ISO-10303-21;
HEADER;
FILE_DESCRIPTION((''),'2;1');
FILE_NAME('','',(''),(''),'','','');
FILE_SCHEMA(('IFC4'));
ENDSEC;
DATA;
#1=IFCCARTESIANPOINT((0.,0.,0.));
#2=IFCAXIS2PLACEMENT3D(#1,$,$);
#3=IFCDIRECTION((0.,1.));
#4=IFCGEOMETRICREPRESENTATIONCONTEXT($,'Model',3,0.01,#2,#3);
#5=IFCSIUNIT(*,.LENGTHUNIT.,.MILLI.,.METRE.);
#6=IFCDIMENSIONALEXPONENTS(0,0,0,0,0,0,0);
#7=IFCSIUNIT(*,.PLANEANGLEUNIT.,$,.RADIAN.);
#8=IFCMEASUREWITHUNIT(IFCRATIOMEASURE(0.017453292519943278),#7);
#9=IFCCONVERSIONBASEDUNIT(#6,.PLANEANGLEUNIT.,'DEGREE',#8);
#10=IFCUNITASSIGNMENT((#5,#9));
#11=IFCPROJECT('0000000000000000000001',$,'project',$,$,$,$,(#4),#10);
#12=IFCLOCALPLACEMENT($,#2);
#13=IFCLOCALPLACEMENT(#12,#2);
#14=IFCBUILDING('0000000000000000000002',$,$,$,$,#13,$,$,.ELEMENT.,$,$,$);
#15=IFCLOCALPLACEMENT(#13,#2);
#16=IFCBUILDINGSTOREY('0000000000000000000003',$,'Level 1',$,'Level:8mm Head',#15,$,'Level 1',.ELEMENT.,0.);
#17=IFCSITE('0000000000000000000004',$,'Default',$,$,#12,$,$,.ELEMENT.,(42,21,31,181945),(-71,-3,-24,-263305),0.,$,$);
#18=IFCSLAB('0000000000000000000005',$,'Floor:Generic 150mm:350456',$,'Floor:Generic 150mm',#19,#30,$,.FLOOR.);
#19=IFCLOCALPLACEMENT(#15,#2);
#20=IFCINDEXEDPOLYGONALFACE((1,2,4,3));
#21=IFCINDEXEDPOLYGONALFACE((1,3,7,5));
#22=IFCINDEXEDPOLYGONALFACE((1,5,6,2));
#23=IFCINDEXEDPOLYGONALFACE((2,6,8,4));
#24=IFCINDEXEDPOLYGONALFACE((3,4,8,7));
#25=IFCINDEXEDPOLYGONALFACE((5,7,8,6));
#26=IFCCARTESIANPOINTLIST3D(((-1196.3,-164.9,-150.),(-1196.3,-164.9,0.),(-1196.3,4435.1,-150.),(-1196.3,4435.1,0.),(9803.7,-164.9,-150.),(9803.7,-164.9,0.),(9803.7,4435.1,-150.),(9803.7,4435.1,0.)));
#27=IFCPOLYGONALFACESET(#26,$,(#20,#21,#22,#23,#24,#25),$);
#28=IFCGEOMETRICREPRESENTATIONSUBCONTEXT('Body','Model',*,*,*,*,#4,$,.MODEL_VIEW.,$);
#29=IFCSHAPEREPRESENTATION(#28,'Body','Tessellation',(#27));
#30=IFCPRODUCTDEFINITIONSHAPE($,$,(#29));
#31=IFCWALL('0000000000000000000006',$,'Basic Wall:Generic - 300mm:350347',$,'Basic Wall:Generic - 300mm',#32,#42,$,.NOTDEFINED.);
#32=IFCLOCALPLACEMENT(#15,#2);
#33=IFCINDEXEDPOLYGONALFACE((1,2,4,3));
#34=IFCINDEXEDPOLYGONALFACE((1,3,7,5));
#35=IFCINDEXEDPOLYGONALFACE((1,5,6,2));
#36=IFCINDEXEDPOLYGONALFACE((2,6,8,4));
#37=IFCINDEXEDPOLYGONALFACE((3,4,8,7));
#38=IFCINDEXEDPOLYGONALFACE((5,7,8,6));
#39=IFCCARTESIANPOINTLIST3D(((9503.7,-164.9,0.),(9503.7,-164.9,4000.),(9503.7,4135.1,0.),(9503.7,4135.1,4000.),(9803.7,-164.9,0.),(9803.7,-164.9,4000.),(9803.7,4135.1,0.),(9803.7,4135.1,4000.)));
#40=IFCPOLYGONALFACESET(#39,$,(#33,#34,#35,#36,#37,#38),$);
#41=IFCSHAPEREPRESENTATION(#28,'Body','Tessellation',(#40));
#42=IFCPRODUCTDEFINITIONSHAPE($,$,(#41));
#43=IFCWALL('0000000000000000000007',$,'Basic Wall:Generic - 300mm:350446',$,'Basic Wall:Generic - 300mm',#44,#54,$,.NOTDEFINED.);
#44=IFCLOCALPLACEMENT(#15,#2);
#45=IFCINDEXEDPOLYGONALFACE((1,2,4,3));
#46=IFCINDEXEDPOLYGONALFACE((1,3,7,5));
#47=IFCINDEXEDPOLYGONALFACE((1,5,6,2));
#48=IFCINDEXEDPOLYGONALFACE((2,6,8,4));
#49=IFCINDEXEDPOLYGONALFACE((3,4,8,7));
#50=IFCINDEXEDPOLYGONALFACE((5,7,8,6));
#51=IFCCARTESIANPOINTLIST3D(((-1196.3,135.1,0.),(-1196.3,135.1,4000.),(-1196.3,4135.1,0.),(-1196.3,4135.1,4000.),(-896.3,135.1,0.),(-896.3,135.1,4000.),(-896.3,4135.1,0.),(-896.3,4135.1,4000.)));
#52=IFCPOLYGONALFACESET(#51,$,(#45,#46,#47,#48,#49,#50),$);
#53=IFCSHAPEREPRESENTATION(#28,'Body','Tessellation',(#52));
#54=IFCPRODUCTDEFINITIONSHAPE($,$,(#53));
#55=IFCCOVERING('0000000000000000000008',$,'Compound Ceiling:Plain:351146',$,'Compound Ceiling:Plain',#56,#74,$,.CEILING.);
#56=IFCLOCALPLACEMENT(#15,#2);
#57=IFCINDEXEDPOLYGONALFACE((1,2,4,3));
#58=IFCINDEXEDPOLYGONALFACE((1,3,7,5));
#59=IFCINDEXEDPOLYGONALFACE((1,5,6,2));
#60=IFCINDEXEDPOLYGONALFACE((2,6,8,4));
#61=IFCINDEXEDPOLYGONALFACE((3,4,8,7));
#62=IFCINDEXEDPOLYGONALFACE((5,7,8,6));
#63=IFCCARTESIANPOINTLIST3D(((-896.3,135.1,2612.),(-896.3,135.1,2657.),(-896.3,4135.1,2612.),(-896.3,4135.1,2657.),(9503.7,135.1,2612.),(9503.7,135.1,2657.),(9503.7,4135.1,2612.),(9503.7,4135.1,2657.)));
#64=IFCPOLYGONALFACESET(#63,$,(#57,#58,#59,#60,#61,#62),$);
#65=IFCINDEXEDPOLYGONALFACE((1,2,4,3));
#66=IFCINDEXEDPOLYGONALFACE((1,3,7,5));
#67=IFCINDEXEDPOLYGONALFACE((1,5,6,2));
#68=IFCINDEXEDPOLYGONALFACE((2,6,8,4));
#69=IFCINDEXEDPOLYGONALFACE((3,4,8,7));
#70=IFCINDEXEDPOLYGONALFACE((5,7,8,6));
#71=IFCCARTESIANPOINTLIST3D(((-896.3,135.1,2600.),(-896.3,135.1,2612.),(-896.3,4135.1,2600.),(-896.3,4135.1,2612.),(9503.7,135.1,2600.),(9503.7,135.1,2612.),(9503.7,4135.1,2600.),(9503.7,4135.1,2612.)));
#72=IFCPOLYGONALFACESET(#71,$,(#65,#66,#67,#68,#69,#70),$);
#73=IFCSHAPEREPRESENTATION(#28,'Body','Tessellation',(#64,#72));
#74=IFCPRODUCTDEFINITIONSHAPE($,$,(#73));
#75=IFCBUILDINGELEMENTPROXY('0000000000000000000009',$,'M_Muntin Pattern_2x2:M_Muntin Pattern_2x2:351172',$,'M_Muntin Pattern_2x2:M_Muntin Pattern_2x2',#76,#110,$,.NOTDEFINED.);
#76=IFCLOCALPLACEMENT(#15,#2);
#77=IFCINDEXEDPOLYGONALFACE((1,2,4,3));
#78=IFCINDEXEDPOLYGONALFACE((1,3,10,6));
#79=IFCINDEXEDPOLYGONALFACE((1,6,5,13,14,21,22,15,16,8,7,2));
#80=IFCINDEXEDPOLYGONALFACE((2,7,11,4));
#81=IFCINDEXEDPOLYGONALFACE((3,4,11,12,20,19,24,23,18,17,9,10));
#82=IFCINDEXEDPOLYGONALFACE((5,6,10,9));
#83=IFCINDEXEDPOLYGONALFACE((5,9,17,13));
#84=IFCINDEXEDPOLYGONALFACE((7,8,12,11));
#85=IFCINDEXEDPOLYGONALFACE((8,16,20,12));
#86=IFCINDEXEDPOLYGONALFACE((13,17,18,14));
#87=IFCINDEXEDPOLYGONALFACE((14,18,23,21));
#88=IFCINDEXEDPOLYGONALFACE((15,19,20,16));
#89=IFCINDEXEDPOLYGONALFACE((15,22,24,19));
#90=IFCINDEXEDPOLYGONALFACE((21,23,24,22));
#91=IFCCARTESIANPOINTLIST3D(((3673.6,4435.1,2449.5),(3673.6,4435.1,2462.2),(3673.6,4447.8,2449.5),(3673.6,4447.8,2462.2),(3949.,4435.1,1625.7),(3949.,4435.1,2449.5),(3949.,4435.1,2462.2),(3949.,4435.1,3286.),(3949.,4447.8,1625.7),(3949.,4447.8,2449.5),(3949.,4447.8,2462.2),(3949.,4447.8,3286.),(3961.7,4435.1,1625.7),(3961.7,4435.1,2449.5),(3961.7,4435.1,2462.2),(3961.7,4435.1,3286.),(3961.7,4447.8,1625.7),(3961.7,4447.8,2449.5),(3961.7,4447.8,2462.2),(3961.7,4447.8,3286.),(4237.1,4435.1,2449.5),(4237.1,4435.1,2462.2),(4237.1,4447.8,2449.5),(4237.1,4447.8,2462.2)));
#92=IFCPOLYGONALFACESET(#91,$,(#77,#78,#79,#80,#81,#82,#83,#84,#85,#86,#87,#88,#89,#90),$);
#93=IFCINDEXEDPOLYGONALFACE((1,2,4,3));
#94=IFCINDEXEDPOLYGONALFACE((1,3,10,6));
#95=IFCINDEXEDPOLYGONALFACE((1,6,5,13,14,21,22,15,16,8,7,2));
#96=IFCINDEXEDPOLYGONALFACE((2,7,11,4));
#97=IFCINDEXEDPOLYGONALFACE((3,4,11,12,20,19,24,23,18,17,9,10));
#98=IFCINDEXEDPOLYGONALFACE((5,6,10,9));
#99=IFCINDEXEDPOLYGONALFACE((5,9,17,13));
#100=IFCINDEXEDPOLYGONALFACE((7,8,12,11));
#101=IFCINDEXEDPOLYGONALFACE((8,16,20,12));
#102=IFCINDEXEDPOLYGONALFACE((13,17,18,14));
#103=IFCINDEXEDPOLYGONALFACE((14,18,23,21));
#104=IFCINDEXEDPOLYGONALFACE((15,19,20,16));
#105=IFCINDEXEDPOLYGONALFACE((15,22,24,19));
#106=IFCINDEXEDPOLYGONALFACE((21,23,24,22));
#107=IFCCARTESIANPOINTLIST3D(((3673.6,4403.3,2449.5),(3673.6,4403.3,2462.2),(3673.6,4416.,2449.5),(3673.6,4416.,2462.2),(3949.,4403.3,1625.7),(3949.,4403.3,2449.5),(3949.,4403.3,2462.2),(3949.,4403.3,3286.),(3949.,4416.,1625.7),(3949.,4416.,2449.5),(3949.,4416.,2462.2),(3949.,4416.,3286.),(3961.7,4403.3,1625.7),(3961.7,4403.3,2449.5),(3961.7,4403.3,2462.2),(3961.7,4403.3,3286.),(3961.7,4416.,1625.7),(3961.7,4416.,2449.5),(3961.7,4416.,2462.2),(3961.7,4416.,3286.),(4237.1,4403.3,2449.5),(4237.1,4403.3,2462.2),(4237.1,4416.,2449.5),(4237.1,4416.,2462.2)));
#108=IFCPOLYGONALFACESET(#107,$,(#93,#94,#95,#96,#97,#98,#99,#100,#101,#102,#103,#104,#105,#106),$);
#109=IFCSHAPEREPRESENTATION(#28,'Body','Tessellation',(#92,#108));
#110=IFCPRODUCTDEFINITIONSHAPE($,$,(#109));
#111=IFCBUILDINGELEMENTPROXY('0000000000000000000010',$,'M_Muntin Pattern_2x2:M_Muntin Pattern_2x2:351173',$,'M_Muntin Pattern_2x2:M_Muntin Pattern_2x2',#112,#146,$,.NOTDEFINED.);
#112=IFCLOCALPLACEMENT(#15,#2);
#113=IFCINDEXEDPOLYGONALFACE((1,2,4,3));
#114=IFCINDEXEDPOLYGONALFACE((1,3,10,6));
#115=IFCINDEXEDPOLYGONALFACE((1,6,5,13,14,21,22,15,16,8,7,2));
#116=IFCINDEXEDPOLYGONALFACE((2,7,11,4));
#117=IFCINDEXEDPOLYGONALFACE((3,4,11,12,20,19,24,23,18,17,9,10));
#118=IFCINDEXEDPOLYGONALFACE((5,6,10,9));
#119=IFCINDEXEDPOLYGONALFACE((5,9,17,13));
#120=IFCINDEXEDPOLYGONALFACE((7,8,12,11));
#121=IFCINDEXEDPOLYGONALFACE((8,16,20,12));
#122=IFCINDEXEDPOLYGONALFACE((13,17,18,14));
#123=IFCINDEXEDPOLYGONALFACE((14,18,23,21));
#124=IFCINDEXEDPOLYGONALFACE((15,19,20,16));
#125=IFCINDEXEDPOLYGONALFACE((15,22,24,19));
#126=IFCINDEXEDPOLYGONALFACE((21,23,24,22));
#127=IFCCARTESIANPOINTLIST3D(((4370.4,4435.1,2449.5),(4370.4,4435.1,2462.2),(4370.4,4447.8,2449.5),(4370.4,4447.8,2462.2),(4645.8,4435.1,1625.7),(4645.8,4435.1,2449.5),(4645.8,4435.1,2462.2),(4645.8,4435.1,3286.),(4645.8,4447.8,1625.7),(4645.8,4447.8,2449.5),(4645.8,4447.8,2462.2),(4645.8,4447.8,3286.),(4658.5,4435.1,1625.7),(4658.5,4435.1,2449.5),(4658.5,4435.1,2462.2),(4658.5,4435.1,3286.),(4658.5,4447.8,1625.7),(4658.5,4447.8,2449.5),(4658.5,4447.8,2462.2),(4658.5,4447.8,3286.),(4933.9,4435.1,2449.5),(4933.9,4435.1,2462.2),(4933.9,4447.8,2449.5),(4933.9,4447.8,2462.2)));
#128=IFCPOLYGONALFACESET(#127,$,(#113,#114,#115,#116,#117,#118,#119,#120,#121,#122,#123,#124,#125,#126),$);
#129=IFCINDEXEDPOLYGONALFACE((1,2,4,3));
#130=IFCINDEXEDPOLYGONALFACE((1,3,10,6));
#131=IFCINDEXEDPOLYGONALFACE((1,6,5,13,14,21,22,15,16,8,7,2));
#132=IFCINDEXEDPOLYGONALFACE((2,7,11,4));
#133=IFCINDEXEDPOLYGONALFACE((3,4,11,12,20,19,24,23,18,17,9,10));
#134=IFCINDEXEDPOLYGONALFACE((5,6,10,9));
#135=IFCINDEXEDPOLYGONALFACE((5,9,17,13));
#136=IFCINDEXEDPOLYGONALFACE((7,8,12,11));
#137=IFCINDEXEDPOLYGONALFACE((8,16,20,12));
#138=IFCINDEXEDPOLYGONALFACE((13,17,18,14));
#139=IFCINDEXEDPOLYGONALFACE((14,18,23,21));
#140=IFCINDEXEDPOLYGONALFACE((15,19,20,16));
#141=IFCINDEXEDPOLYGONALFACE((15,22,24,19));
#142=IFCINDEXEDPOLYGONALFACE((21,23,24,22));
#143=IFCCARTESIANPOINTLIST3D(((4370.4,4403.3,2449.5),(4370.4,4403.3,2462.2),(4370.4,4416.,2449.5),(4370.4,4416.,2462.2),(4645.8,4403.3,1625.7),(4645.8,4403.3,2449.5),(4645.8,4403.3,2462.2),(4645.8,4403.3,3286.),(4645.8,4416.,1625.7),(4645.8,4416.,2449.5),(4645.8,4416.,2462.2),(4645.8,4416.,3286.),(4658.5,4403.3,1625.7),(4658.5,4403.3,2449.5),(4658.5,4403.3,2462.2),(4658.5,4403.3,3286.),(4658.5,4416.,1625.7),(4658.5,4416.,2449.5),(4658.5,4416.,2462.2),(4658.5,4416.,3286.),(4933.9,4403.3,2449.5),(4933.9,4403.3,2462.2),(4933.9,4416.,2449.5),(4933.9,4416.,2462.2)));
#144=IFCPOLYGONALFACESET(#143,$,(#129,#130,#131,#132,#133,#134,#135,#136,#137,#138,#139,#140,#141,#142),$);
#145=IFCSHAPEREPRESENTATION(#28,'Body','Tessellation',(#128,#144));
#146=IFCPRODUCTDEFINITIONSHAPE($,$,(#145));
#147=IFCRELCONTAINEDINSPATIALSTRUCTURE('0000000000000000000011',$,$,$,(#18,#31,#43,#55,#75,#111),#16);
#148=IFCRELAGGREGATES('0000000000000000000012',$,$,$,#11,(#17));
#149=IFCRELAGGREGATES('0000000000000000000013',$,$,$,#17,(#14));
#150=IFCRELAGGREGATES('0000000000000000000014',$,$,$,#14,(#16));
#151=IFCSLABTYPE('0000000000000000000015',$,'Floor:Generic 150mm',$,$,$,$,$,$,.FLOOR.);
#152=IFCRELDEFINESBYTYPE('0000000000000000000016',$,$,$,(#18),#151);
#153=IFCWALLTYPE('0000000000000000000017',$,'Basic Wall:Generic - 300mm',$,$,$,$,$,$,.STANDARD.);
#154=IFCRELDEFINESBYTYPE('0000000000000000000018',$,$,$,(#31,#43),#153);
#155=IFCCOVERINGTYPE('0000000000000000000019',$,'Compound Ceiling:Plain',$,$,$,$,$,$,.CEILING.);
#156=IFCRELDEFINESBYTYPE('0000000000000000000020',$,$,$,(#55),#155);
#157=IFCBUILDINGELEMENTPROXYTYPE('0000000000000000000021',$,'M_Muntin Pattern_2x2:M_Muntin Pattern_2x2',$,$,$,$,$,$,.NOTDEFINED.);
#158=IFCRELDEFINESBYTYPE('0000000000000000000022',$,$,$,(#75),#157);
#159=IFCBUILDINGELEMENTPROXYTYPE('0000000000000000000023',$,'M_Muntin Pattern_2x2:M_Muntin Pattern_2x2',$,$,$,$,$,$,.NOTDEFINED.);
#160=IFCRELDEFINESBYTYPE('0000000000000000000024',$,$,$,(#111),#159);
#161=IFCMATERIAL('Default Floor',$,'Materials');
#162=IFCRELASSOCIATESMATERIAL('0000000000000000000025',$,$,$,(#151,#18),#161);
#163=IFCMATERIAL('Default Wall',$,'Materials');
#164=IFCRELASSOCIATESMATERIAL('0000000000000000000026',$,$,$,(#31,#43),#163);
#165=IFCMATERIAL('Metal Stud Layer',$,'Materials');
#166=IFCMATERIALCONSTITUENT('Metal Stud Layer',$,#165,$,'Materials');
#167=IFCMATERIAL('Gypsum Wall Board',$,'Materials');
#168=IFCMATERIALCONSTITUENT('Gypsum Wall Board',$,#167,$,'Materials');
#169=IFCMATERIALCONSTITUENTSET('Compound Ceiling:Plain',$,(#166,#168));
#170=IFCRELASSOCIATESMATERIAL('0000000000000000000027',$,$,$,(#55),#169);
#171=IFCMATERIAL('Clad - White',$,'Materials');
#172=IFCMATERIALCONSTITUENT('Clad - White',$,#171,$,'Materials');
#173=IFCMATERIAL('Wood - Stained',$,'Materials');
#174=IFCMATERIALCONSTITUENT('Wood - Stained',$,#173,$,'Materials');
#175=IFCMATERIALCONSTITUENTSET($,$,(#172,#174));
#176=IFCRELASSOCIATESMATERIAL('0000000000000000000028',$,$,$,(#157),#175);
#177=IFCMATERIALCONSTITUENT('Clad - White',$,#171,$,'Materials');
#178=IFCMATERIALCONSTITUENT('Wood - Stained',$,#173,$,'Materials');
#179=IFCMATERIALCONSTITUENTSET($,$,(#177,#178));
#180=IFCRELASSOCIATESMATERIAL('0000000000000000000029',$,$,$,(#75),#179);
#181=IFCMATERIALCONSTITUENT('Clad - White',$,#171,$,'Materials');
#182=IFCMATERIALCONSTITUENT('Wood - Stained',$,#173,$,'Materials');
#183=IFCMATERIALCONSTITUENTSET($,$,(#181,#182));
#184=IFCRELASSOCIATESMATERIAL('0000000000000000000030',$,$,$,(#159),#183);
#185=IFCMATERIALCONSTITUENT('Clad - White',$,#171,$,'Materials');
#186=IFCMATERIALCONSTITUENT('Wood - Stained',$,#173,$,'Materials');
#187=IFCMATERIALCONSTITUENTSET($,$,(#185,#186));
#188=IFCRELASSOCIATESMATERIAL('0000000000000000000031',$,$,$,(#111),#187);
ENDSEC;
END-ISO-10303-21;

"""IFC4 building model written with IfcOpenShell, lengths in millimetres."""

from ifc_helpers import new_model, entity, si_unit, converted_unit, direction, frame, origin, place, context, subcontext, project, spatial, indexed_curve, outline, extrude, source, transform, mapped, material, constituent, constituent_set, type_object, type_shapes, element, save


model = new_model("IFC4")

# Units and contexts
model_context = context("Model", 3, precision=0.01, world=origin(), true_north=direction((0.0, 1.0)))
body_context = subcontext(model_context, "Body", "Model", "MODEL_VIEW")
ifc_project = project(units=[si_unit("LENGTHUNIT", "METRE", prefix="MILLI"), converted_unit("PLANEANGLEUNIT", "DEGREE", entity("IfcRatioMeasure", 0.017453292519943278), si_unit("PLANEANGLEUNIT", "RADIAN"), dimensions=[0, 0, 0, 0, 0, 0, 0])], contexts=[model_context])

# Site, building, storey
site_placement = place(None, origin())
site = spatial("IfcSite", under=ifc_project, at=site_placement, Name="Default", CompositionType="ELEMENT", RefLatitude=(42, 21, 31, 181945), RefLongitude=(-71, -3, -24, -263305), RefElevation=0.0)
building_placement = place(site_placement, origin())
building = spatial("IfcBuilding", under=site, at=building_placement, CompositionType="ELEMENT")
storey_placement = place(building_placement, origin())
storey = spatial("IfcBuildingStorey", under=building, at=storey_placement, Name="Level 1", ObjectType="Level:8mm Head", LongName="Level 1", CompositionType="ELEMENT", Elevation=0.0)

# Slab
ifc_material_1 = material(Name="Default Floor", Category="Materials")
slab_type = type_object("IfcSlabType", Name="Floor:Generic 150mm", PredefinedType="FLOOR", material=ifc_material_1)
slab_placement = place(storey_placement, origin())
element("IfcSlab", 1, at=slab_placement, inside=storey, type_object=slab_type, material=ifc_material_1, Name="Floor:Generic 150mm:350456", ObjectType="Floor:Generic 150mm", PredefinedType="FLOOR", context=body_context, shape_type="SweptSolid", body=[
    extrude(outline(indexed_curve([(-2300.0, -5500.0), (2300.0, -5500.0), (2300.0, 5500.0), (-2300.0, 5500.0), (-2300.0, -5500.0)], self_intersect=False)), frame((4303.7, 2135.1, 0.0), z_axis=(0.0, 0.0, -1.0), x_axis=(0.0, 1.0, 0.0)), (0.0, 0.0, 1.0), 150.0),
])

# Walls
ifc_material_2 = material(Name="Default Wall", Category="Materials")
wall_type = type_object("IfcWallType", Name="Basic Wall:Generic - 300mm", PredefinedType="STANDARD")
wall_1_placement = place(storey_placement, frame((9653.7, 4135.1, 0.0), z_axis=(0.0, 0.0, 1.0), x_axis=(0.0, -1.0, 0.0)))
element("IfcWall", 2, at=wall_1_placement, inside=storey, type_object=wall_type, material=ifc_material_2, Name="Basic Wall:Generic - 300mm:350347", ObjectType="Basic Wall:Generic - 300mm", PredefinedType="NOTDEFINED", context=body_context, shape_type="SweptSolid", body=[
    extrude(outline(indexed_curve([(4300.0, 150.0), (0.0, 150.0), (0.0, -150.0), (4300.0, -150.0), (4300.0, 150.0)], self_intersect=False)), origin(), (0.0, 0.0, 1.0), 4000.0),
])
wall_2_placement = place(storey_placement, frame((-1046.3, 135.1, 0.0), z_axis=(0.0, 0.0, 1.0), x_axis=(0.0, 1.0, 0.0)))
element("IfcWall", 3, at=wall_2_placement, inside=storey, type_object=wall_type, material=ifc_material_2, Name="Basic Wall:Generic - 300mm:350446", ObjectType="Basic Wall:Generic - 300mm", PredefinedType="NOTDEFINED", context=body_context, shape_type="SweptSolid", body=[
    extrude(outline(indexed_curve([(4000.0, 150.0), (0.0, 150.0), (0.0, -150.0), (4000.0, -150.0), (4000.0, 150.0)], self_intersect=False)), origin(), (0.0, 0.0, 1.0), 4000.0),
])

# Covering
ifc_material_3 = material(Name="Metal Stud Layer", Category="Materials")
ifc_constituent_1 = constituent(ifc_material_3, Name="Metal Stud Layer", Category="Materials")
ifc_material_4 = material(Name="Gypsum Wall Board", Category="Materials")
ifc_constituent_2 = constituent(ifc_material_4, Name="Gypsum Wall Board", Category="Materials")
ifc_constituent_set_1 = constituent_set(constituents=[ifc_constituent_1, ifc_constituent_2], Name="Compound Ceiling:Plain")
covering_type = type_object("IfcCoveringType", Name="Compound Ceiling:Plain", PredefinedType="CEILING")
covering_placement = place(storey_placement, origin())
element("IfcCovering", 4, at=covering_placement, inside=storey, type_object=covering_type, material=ifc_constituent_set_1, Name="Compound Ceiling:Plain:351146", ObjectType="Compound Ceiling:Plain", PredefinedType="CEILING", context=body_context, shape_type="SweptSolid", body=[
    extrude(outline(indexed_curve([(-5200.0, -2000.0), (5200.0, -2000.0), (5200.0, 2000.0), (-5200.0, 2000.0), (-5200.0, -2000.0)], self_intersect=False)), frame((4303.7, 2135.1, 2612.0)), (0.0, 0.0, 1.0), 45.0),
    extrude(outline(indexed_curve([(-2000.0, -5200.0), (2000.0, -5200.0), (2000.0, 5200.0), (-2000.0, 5200.0), (-2000.0, -5200.0)], self_intersect=False)), frame((4303.7, 2135.1, 2600.0), z_axis=(0.0, 0.0, 1.0), x_axis=(0.0, -1.0, 0.0)), (0.0, 0.0, 1.0), 12.0),
])

# Building element proxies
ifc_material_5 = material(Name="Clad - White", Category="Materials")
ifc_constituent_3 = constituent(ifc_material_5, Name="Clad - White", Category="Materials")
ifc_material_6 = material(Name="Wood - Stained", Category="Materials")
ifc_constituent_4 = constituent(ifc_material_6, Name="Wood - Stained", Category="Materials")
ifc_constituent_set_2 = constituent_set(constituents=[ifc_constituent_3, ifc_constituent_4])
ifc_constituent_5 = constituent(ifc_material_5, Name="Clad - White", Category="Materials")
ifc_constituent_6 = constituent(ifc_material_6, Name="Wood - Stained", Category="Materials")
ifc_constituent_set_3 = constituent_set(constituents=[ifc_constituent_5, ifc_constituent_6])
building_element_proxy_type_1 = type_object("IfcBuildingElementProxyType", Name="M_Muntin Pattern_2x2:M_Muntin Pattern_2x2", PredefinedType="NOTDEFINED", material=ifc_constituent_set_3)
shared_shape_1 = source(origin(), body_context, "Body", "SweptSolid", [
    extrude(outline(indexed_curve([(6.4, -6.4), (830.1, -6.4), (830.1, 6.3), (6.4, 6.3), (6.4, 281.7), (-6.3, 281.7), (-6.3, 6.3), (-830.2, 6.3), (-830.2, -6.4), (-6.3, -6.4), (-6.3, -281.7), (6.4, -281.7), (6.4, -6.4)], self_intersect=False)), frame((0.0, 9.5, 830.1), z_axis=(0.0, 1.0, 0.0), x_axis=(0.0, 0.0, 1.0)), (0.0, 0.0, 1.0), 12.7),
    extrude(outline(indexed_curve([(6.4, -6.4), (830.2, -6.4), (830.2, 6.3), (6.4, 6.3), (6.4, 281.7), (-6.3, 281.7), (-6.3, 6.3), (-830.2, 6.3), (-830.2, -6.4), (-6.3, -6.4), (-6.3, -281.7), (6.4, -281.7), (6.4, -6.4)], self_intersect=False)), frame((0.0, -22.2, 830.2), z_axis=(0.0, 1.0, 0.0), x_axis=(0.0, 0.0, 1.0)), (0.0, 0.0, 1.0), 12.7),
])
type_shapes(building_element_proxy_type_1, [shared_shape_1])
proxy_1_placement = place(storey_placement, frame((3955.3, 4425.5, 1625.7)))
element("IfcBuildingElementProxy", 5, at=proxy_1_placement, inside=storey, type_object=building_element_proxy_type_1, material=ifc_constituent_set_2, Name="M_Muntin Pattern_2x2:M_Muntin Pattern_2x2:351172", ObjectType="M_Muntin Pattern_2x2:M_Muntin Pattern_2x2", PredefinedType="NOTDEFINED", context=body_context, shape_type="MappedRepresentation", body=[
    mapped(shared_shape_1, transform((0.0, 0.0, 0.0), scale=1.0)),
])
ifc_constituent_7 = constituent(ifc_material_5, Name="Clad - White", Category="Materials")
ifc_constituent_8 = constituent(ifc_material_6, Name="Wood - Stained", Category="Materials")
ifc_constituent_set_4 = constituent_set(constituents=[ifc_constituent_7, ifc_constituent_8])
ifc_constituent_9 = constituent(ifc_material_5, Name="Clad - White", Category="Materials")
ifc_constituent_10 = constituent(ifc_material_6, Name="Wood - Stained", Category="Materials")
ifc_constituent_set_5 = constituent_set(constituents=[ifc_constituent_9, ifc_constituent_10])
building_element_proxy_type_2 = type_object("IfcBuildingElementProxyType", Name="M_Muntin Pattern_2x2:M_Muntin Pattern_2x2", PredefinedType="NOTDEFINED", material=ifc_constituent_set_5)
shared_shape_2 = source(origin(), body_context, "Body", "SweptSolid", [
    extrude(outline(indexed_curve([(6.4, -6.4), (830.1, -6.4), (830.1, 6.3), (6.4, 6.3), (6.4, 281.7), (-6.3, 281.7), (-6.3, 6.3), (-830.2, 6.3), (-830.2, -6.4), (-6.3, -6.4), (-6.3, -281.7), (6.4, -281.7), (6.4, -6.4)], self_intersect=False)), frame((0.0, -22.2, 830.1), z_axis=(0.0, 1.0, 0.0), x_axis=(0.0, 0.0, 1.0)), (0.0, 0.0, 1.0), 12.7),
    extrude(outline(indexed_curve([(6.4, -6.4), (830.2, -6.4), (830.2, 6.3), (6.4, 6.3), (6.4, 281.7), (-6.3, 281.7), (-6.3, 6.3), (-830.2, 6.3), (-830.2, -6.4), (-6.3, -6.4), (-6.3, -281.7), (6.4, -281.7), (6.4, -6.4)], self_intersect=False)), frame((0.0, 9.5, 830.2), z_axis=(0.0, 1.0, 0.0), x_axis=(0.0, 0.0, 1.0)), (0.0, 0.0, 1.0), 12.7),
])
type_shapes(building_element_proxy_type_2, [shared_shape_2])
proxy_2_placement = place(storey_placement, frame((4652.1, 4425.5, 1625.7), z_axis=(0.0, 0.0, 1.0), x_axis=(-1.0, 0.0, 0.0)))
element("IfcBuildingElementProxy", 6, at=proxy_2_placement, inside=storey, type_object=building_element_proxy_type_2, material=ifc_constituent_set_4, Name="M_Muntin Pattern_2x2:M_Muntin Pattern_2x2:351173", ObjectType="M_Muntin Pattern_2x2:M_Muntin Pattern_2x2", PredefinedType="NOTDEFINED", context=body_context, shape_type="MappedRepresentation", body=[
    mapped(shared_shape_2, transform((0.0, 0.0, 0.0), scale=1.0)),
])

save(model, "model.ifc")
